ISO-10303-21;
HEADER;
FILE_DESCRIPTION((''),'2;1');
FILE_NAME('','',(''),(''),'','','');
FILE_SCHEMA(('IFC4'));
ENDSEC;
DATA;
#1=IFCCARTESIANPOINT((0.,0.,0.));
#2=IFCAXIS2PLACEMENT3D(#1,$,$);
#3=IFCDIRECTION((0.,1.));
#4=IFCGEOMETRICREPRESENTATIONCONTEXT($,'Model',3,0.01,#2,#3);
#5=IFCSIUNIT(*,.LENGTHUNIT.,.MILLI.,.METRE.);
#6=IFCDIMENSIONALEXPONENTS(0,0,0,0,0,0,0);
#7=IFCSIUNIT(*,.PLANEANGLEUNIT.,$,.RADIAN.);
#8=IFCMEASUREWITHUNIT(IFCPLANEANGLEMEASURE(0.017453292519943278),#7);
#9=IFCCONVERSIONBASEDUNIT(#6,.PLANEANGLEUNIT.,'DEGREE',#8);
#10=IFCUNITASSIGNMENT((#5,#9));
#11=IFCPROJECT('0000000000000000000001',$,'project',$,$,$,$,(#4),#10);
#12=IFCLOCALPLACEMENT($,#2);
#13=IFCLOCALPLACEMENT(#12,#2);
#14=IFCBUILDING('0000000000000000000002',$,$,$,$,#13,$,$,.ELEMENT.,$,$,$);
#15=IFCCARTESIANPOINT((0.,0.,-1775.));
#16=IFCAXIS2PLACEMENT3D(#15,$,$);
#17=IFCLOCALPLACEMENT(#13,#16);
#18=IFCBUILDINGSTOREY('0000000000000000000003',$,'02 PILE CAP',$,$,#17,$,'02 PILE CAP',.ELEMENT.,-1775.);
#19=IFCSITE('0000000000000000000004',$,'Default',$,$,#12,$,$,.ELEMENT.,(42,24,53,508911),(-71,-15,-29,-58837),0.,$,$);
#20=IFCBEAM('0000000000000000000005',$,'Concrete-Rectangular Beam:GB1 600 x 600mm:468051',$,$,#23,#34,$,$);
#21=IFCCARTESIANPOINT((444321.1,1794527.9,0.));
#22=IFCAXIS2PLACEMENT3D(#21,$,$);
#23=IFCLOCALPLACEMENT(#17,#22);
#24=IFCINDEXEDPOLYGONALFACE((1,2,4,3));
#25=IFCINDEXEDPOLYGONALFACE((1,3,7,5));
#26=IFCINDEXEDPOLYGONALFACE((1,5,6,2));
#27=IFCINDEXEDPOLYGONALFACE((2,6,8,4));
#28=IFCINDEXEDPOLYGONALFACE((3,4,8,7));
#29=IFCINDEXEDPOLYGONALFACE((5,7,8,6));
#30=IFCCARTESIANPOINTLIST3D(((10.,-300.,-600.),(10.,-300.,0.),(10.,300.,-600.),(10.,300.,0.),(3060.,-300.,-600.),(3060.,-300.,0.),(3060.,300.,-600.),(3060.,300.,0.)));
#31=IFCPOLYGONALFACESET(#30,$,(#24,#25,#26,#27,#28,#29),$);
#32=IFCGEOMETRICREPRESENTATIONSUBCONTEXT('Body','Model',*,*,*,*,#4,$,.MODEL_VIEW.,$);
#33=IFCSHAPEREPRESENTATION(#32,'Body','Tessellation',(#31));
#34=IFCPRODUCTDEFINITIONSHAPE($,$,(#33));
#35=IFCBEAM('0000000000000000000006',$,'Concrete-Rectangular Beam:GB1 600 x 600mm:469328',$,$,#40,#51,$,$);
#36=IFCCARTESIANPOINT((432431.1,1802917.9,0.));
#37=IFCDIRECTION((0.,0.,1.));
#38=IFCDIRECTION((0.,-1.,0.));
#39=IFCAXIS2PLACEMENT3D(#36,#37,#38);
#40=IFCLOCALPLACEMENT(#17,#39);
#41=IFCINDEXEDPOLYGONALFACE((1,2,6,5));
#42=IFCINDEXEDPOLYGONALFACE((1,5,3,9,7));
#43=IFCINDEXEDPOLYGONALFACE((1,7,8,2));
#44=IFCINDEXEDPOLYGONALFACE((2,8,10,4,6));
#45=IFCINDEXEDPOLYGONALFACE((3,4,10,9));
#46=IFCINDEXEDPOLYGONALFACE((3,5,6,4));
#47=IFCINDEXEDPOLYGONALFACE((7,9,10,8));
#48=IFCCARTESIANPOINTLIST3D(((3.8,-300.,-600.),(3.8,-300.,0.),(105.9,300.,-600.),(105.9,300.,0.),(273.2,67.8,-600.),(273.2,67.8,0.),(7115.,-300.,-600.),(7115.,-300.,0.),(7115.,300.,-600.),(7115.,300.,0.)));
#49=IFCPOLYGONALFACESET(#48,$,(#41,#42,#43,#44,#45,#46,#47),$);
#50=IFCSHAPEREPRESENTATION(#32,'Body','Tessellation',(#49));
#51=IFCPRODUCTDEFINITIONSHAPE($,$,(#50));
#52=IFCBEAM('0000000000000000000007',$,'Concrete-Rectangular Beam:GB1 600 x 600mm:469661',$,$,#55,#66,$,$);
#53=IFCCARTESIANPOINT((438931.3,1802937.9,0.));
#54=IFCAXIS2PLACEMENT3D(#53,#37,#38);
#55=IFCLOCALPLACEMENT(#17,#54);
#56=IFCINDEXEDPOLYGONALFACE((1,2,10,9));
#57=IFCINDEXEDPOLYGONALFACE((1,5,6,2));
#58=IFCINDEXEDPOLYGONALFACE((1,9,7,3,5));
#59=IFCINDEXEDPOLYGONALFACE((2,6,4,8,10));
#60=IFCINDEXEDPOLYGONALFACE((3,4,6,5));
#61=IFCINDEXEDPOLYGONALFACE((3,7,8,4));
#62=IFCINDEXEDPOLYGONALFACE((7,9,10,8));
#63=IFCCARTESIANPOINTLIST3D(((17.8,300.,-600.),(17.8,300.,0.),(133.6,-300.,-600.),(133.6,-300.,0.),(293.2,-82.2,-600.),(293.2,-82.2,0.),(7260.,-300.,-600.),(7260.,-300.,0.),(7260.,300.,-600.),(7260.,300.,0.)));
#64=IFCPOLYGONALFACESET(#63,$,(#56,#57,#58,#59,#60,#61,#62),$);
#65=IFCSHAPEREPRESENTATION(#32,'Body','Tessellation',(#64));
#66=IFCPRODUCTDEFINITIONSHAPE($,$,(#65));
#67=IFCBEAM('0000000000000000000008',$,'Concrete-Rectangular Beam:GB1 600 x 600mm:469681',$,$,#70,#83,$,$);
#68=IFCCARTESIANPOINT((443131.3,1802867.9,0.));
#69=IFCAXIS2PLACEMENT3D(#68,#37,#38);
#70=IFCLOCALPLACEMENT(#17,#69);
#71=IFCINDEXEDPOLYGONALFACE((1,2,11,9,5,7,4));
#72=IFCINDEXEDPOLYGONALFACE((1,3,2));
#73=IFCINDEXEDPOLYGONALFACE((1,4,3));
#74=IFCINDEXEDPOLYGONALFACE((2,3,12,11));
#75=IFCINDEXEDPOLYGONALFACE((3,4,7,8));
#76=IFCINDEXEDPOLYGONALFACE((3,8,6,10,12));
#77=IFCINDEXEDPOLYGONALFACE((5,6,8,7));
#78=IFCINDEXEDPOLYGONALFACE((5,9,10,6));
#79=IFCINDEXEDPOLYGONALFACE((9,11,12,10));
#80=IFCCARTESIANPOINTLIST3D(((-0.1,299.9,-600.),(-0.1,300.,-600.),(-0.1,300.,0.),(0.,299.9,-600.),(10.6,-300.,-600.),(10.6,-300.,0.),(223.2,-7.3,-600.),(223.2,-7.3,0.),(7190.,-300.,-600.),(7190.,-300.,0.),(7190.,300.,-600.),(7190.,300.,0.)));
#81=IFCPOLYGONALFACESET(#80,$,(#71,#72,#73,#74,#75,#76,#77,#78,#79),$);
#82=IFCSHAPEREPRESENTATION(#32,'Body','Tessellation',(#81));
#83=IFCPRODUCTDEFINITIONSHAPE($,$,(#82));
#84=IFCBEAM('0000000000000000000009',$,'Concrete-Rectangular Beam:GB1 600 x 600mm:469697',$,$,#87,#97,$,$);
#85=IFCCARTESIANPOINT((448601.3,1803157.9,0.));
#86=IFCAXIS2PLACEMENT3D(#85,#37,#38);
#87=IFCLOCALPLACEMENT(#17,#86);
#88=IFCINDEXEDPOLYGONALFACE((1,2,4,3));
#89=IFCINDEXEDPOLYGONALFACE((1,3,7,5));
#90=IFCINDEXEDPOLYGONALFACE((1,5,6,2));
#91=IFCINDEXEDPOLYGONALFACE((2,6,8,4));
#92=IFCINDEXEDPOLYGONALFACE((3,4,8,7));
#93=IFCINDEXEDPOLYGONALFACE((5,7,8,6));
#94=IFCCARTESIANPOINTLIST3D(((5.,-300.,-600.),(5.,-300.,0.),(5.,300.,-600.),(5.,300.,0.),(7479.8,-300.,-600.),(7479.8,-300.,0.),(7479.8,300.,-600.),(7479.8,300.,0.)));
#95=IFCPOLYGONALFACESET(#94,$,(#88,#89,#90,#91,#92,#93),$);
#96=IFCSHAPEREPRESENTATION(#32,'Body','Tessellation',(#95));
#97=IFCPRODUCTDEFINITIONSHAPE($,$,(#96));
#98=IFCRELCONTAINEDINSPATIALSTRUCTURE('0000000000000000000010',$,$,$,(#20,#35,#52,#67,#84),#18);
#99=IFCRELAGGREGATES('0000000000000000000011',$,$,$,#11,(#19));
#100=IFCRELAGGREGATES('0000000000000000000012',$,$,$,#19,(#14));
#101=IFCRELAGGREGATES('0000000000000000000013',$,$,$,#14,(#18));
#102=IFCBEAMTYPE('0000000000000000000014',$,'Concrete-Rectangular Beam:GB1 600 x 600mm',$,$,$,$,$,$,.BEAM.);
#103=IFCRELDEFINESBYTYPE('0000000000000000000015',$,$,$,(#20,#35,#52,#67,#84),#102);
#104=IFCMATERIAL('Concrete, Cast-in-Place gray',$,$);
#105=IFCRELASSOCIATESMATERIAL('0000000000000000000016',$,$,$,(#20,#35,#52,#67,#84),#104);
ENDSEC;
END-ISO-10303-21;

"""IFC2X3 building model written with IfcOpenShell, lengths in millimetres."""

from ifc_helpers import new_model, entity, si_unit, converted_unit, direction, frame, frame_2d, origin, origin_2d_with_axis, place, context, subcontext, project, spatial, polyline, rectangle, extrude, clip, bounded_halfspace, material, type_object, element, save


model = new_model("IFC2X3")

# Units and contexts
model_context = context("Model", 3, precision=0.01, world=origin(), true_north=direction((0.0, 1.0)))
body_context = subcontext(model_context, "Body", "Model", "MODEL_VIEW")
ifc_project = project(units=[si_unit("LENGTHUNIT", "METRE", prefix="MILLI"), converted_unit("PLANEANGLEUNIT", "DEGREE", entity("IfcPlaneAngleMeasure", 0.017453292519943278), si_unit("PLANEANGLEUNIT", "RADIAN"), dimensions=[0, 0, 0, 0, 0, 0, 0])], contexts=[model_context])

# Site, building, storey
site_placement = place(None, origin())
site = spatial("IfcSite", under=ifc_project, at=site_placement, Name="Default", CompositionType="ELEMENT", RefLatitude=(42, 24, 53, 508911), RefLongitude=(-71, -15, -29, -58837), RefElevation=0.0)
building_placement = place(site_placement, origin())
building = spatial("IfcBuilding", under=site, at=building_placement, CompositionType="ELEMENT")
storey_placement = place(building_placement, frame((0.0, 0.0, -1775.0)))
storey = spatial("IfcBuildingStorey", under=building, at=storey_placement, Name="02 PILE CAP", LongName="02 PILE CAP", CompositionType="ELEMENT", Elevation=-1775.0)

# Beams
ifc_material_1 = material(Name="Concrete, Cast-in-Place gray")
beam_type_1 = type_object("IfcBeamType", Name="Concrete-Rectangular Beam:GB1 600 x 600mm", PredefinedType="BEAM")
beam_1_placement = place(storey_placement, frame((444321.1, 1794527.9, 0.0)))
element("IfcBeam", 1, at=beam_1_placement, inside=storey, type_object=beam_type_1, material=ifc_material_1, Name="Concrete-Rectangular Beam:GB1 600 x 600mm:468051", context=body_context, shape_type="SweptSolid", body=[
    extrude(rectangle(XDim=600.0, YDim=600.0, at=origin_2d_with_axis()), frame((10.0, 0.0, -300.0), z_axis=(1.0, 0.0, 0.0), x_axis=(0.0, 0.0, -1.0)), (0.0, 0.0, 1.0), 3050.0),
])
beam_2_placement = place(storey_placement, frame((432431.1, 1802917.9, 0.0), z_axis=(0.0, 0.0, 1.0), x_axis=(0.0, -1.0, 0.0)))
element("IfcBeam", 2, at=beam_2_placement, inside=storey, type_object=beam_type_1, material=ifc_material_1, Name="Concrete-Rectangular Beam:GB1 600 x 600mm:469328", context=body_context, shape_type="Clipping", body=[
    clip(clip(extrude(rectangle(XDim=600.0, YDim=600.0, at=frame_2d((0.0, 0.0), x_axis=(1.0, 0.0))), frame((3.8, 0.0, -300.0), z_axis=(1.0, 0.0, 0.0), x_axis=(0.0, 0.0, -1.0)), (0.0, 0.0, 1.0), 7111.2), bounded_halfspace(frame((-986.7, 1816.3, -1000.0), z_axis=(-0.811306, -0.584622, 0.0), x_axis=(0.0, 0.0, 1.0)), False, frame((3.8, 0.0, -300.0), z_axis=(1.0, 0.0, 0.0), x_axis=(0.0, 0.0, -1.0)), polyline([(300.0, 67.8), (-300.0, 67.8), (-300.0, 300.0), (300.0, 300.0), (300.0, 67.8)]))), bounded_halfspace(frame((273.2, 67.8, -1000.0), z_axis=(-0.806716, 0.59094, 0.0), x_axis=(0.0, 0.0, 1.0)), False, frame((3.8, 0.0, -300.0), z_axis=(1.0, 0.0, 0.0), x_axis=(0.0, 0.0, -1.0)), polyline([(-300.0, 67.8), (300.0, 67.8), (300.0, -300.0), (-300.0, -300.0), (-300.0, 67.8)]))),
])
beam_3_placement = place(storey_placement, frame((438931.3, 1802937.9, 0.0), z_axis=(0.0, 0.0, 1.0), x_axis=(0.0, -1.0, 0.0)))
element("IfcBeam", 3, at=beam_3_placement, inside=storey, type_object=beam_type_1, material=ifc_material_1, Name="Concrete-Rectangular Beam:GB1 600 x 600mm:469661", context=body_context, shape_type="Clipping", body=[
    clip(clip(extrude(rectangle(XDim=600.0, YDim=600.0, at=frame_2d((0.0, 0.0), x_axis=(1.0, 0.0))), frame((17.8, 0.0, -300.0), z_axis=(1.0, 0.0, 0.0), x_axis=(0.0, 0.0, -1.0)), (0.0, 0.0, 1.0), 7242.2), bounded_halfspace(frame((-966.7, 1666.3, -1000.0), z_axis=(-0.811306, -0.584622, 0.0), x_axis=(0.0, 0.0, 1.0)), False, frame((17.8, 0.0, -300.0), z_axis=(1.0, 0.0, 0.0), x_axis=(0.0, 0.0, -1.0)), polyline([(300.0, -82.2), (-300.0, -82.2), (-300.0, 300.0), (300.0, 300.0), (300.0, -82.2)]))), bounded_halfspace(frame((293.2, -82.2, -1000.0), z_axis=(-0.806716, 0.59094, 0.0), x_axis=(0.0, 0.0, 1.0)), False, frame((17.8, 0.0, -300.0), z_axis=(1.0, 0.0, 0.0), x_axis=(0.0, 0.0, -1.0)), polyline([(-300.0, -82.2), (300.0, -82.2), (300.0, -300.0), (-300.0, -300.0), (-300.0, -82.2)]))),
])
beam_4_placement = place(storey_placement, frame((443131.3, 1802867.9, 0.0), z_axis=(0.0, 0.0, 1.0), x_axis=(0.0, -1.0, 0.0)))
element("IfcBeam", 4, at=beam_4_placement, inside=storey, type_object=beam_type_1, material=ifc_material_1, Name="Concrete-Rectangular Beam:GB1 600 x 600mm:469681", context=body_context, shape_type="Clipping", body=[
    clip(clip(extrude(rectangle(XDim=600.0, YDim=600.0, at=frame_2d((0.0, 0.0), x_axis=(1.0, 0.0))), frame((-0.1, 0.0, -300.0), z_axis=(1.0, 0.0, 0.0), x_axis=(0.0, 0.0, -1.0)), (0.0, 0.0, 1.0), 7190.1), bounded_halfspace(frame((-1043.5, 1736.2, -1000.0), z_axis=(-0.809017, -0.587785, 0.0), x_axis=(0.0, 0.0, 1.0)), False, frame((-0.1, 0.0, -300.0), z_axis=(1.0, 0.0, 0.0), x_axis=(0.0, 0.0, -1.0)), polyline([(300.0, -7.3), (-300.0, -7.3), (-300.0, 300.0), (300.0, 299.9), (300.0, -7.3)]))), bounded_halfspace(frame((223.2, -7.3, -1000.0), z_axis=(-0.809017, 0.587785, 0.0), x_axis=(0.0, 0.0, 1.0)), False, frame((-0.1, 0.0, -300.0), z_axis=(1.0, 0.0, 0.0), x_axis=(0.0, 0.0, -1.0)), polyline([(-300.0, -7.3), (300.0, -7.3), (300.0, -300.0), (-300.0, -300.0), (-300.0, -7.3)]))),
])
beam_5_placement = place(storey_placement, frame((448601.3, 1803157.9, 0.0), z_axis=(0.0, 0.0, 1.0), x_axis=(0.0, -1.0, 0.0)))
element("IfcBeam", 5, at=beam_5_placement, inside=storey, type_object=beam_type_1, material=ifc_material_1, Name="Concrete-Rectangular Beam:GB1 600 x 600mm:469697", context=body_context, shape_type="SweptSolid", body=[
    extrude(rectangle(XDim=600.0, YDim=600.0, at=origin_2d_with_axis()), frame((5.0, 0.0, -300.0), z_axis=(1.0, 0.0, 0.0), x_axis=(0.0, 0.0, -1.0)), (0.0, 0.0, 1.0), 7474.8),
])

save(model, "model.ifc")
